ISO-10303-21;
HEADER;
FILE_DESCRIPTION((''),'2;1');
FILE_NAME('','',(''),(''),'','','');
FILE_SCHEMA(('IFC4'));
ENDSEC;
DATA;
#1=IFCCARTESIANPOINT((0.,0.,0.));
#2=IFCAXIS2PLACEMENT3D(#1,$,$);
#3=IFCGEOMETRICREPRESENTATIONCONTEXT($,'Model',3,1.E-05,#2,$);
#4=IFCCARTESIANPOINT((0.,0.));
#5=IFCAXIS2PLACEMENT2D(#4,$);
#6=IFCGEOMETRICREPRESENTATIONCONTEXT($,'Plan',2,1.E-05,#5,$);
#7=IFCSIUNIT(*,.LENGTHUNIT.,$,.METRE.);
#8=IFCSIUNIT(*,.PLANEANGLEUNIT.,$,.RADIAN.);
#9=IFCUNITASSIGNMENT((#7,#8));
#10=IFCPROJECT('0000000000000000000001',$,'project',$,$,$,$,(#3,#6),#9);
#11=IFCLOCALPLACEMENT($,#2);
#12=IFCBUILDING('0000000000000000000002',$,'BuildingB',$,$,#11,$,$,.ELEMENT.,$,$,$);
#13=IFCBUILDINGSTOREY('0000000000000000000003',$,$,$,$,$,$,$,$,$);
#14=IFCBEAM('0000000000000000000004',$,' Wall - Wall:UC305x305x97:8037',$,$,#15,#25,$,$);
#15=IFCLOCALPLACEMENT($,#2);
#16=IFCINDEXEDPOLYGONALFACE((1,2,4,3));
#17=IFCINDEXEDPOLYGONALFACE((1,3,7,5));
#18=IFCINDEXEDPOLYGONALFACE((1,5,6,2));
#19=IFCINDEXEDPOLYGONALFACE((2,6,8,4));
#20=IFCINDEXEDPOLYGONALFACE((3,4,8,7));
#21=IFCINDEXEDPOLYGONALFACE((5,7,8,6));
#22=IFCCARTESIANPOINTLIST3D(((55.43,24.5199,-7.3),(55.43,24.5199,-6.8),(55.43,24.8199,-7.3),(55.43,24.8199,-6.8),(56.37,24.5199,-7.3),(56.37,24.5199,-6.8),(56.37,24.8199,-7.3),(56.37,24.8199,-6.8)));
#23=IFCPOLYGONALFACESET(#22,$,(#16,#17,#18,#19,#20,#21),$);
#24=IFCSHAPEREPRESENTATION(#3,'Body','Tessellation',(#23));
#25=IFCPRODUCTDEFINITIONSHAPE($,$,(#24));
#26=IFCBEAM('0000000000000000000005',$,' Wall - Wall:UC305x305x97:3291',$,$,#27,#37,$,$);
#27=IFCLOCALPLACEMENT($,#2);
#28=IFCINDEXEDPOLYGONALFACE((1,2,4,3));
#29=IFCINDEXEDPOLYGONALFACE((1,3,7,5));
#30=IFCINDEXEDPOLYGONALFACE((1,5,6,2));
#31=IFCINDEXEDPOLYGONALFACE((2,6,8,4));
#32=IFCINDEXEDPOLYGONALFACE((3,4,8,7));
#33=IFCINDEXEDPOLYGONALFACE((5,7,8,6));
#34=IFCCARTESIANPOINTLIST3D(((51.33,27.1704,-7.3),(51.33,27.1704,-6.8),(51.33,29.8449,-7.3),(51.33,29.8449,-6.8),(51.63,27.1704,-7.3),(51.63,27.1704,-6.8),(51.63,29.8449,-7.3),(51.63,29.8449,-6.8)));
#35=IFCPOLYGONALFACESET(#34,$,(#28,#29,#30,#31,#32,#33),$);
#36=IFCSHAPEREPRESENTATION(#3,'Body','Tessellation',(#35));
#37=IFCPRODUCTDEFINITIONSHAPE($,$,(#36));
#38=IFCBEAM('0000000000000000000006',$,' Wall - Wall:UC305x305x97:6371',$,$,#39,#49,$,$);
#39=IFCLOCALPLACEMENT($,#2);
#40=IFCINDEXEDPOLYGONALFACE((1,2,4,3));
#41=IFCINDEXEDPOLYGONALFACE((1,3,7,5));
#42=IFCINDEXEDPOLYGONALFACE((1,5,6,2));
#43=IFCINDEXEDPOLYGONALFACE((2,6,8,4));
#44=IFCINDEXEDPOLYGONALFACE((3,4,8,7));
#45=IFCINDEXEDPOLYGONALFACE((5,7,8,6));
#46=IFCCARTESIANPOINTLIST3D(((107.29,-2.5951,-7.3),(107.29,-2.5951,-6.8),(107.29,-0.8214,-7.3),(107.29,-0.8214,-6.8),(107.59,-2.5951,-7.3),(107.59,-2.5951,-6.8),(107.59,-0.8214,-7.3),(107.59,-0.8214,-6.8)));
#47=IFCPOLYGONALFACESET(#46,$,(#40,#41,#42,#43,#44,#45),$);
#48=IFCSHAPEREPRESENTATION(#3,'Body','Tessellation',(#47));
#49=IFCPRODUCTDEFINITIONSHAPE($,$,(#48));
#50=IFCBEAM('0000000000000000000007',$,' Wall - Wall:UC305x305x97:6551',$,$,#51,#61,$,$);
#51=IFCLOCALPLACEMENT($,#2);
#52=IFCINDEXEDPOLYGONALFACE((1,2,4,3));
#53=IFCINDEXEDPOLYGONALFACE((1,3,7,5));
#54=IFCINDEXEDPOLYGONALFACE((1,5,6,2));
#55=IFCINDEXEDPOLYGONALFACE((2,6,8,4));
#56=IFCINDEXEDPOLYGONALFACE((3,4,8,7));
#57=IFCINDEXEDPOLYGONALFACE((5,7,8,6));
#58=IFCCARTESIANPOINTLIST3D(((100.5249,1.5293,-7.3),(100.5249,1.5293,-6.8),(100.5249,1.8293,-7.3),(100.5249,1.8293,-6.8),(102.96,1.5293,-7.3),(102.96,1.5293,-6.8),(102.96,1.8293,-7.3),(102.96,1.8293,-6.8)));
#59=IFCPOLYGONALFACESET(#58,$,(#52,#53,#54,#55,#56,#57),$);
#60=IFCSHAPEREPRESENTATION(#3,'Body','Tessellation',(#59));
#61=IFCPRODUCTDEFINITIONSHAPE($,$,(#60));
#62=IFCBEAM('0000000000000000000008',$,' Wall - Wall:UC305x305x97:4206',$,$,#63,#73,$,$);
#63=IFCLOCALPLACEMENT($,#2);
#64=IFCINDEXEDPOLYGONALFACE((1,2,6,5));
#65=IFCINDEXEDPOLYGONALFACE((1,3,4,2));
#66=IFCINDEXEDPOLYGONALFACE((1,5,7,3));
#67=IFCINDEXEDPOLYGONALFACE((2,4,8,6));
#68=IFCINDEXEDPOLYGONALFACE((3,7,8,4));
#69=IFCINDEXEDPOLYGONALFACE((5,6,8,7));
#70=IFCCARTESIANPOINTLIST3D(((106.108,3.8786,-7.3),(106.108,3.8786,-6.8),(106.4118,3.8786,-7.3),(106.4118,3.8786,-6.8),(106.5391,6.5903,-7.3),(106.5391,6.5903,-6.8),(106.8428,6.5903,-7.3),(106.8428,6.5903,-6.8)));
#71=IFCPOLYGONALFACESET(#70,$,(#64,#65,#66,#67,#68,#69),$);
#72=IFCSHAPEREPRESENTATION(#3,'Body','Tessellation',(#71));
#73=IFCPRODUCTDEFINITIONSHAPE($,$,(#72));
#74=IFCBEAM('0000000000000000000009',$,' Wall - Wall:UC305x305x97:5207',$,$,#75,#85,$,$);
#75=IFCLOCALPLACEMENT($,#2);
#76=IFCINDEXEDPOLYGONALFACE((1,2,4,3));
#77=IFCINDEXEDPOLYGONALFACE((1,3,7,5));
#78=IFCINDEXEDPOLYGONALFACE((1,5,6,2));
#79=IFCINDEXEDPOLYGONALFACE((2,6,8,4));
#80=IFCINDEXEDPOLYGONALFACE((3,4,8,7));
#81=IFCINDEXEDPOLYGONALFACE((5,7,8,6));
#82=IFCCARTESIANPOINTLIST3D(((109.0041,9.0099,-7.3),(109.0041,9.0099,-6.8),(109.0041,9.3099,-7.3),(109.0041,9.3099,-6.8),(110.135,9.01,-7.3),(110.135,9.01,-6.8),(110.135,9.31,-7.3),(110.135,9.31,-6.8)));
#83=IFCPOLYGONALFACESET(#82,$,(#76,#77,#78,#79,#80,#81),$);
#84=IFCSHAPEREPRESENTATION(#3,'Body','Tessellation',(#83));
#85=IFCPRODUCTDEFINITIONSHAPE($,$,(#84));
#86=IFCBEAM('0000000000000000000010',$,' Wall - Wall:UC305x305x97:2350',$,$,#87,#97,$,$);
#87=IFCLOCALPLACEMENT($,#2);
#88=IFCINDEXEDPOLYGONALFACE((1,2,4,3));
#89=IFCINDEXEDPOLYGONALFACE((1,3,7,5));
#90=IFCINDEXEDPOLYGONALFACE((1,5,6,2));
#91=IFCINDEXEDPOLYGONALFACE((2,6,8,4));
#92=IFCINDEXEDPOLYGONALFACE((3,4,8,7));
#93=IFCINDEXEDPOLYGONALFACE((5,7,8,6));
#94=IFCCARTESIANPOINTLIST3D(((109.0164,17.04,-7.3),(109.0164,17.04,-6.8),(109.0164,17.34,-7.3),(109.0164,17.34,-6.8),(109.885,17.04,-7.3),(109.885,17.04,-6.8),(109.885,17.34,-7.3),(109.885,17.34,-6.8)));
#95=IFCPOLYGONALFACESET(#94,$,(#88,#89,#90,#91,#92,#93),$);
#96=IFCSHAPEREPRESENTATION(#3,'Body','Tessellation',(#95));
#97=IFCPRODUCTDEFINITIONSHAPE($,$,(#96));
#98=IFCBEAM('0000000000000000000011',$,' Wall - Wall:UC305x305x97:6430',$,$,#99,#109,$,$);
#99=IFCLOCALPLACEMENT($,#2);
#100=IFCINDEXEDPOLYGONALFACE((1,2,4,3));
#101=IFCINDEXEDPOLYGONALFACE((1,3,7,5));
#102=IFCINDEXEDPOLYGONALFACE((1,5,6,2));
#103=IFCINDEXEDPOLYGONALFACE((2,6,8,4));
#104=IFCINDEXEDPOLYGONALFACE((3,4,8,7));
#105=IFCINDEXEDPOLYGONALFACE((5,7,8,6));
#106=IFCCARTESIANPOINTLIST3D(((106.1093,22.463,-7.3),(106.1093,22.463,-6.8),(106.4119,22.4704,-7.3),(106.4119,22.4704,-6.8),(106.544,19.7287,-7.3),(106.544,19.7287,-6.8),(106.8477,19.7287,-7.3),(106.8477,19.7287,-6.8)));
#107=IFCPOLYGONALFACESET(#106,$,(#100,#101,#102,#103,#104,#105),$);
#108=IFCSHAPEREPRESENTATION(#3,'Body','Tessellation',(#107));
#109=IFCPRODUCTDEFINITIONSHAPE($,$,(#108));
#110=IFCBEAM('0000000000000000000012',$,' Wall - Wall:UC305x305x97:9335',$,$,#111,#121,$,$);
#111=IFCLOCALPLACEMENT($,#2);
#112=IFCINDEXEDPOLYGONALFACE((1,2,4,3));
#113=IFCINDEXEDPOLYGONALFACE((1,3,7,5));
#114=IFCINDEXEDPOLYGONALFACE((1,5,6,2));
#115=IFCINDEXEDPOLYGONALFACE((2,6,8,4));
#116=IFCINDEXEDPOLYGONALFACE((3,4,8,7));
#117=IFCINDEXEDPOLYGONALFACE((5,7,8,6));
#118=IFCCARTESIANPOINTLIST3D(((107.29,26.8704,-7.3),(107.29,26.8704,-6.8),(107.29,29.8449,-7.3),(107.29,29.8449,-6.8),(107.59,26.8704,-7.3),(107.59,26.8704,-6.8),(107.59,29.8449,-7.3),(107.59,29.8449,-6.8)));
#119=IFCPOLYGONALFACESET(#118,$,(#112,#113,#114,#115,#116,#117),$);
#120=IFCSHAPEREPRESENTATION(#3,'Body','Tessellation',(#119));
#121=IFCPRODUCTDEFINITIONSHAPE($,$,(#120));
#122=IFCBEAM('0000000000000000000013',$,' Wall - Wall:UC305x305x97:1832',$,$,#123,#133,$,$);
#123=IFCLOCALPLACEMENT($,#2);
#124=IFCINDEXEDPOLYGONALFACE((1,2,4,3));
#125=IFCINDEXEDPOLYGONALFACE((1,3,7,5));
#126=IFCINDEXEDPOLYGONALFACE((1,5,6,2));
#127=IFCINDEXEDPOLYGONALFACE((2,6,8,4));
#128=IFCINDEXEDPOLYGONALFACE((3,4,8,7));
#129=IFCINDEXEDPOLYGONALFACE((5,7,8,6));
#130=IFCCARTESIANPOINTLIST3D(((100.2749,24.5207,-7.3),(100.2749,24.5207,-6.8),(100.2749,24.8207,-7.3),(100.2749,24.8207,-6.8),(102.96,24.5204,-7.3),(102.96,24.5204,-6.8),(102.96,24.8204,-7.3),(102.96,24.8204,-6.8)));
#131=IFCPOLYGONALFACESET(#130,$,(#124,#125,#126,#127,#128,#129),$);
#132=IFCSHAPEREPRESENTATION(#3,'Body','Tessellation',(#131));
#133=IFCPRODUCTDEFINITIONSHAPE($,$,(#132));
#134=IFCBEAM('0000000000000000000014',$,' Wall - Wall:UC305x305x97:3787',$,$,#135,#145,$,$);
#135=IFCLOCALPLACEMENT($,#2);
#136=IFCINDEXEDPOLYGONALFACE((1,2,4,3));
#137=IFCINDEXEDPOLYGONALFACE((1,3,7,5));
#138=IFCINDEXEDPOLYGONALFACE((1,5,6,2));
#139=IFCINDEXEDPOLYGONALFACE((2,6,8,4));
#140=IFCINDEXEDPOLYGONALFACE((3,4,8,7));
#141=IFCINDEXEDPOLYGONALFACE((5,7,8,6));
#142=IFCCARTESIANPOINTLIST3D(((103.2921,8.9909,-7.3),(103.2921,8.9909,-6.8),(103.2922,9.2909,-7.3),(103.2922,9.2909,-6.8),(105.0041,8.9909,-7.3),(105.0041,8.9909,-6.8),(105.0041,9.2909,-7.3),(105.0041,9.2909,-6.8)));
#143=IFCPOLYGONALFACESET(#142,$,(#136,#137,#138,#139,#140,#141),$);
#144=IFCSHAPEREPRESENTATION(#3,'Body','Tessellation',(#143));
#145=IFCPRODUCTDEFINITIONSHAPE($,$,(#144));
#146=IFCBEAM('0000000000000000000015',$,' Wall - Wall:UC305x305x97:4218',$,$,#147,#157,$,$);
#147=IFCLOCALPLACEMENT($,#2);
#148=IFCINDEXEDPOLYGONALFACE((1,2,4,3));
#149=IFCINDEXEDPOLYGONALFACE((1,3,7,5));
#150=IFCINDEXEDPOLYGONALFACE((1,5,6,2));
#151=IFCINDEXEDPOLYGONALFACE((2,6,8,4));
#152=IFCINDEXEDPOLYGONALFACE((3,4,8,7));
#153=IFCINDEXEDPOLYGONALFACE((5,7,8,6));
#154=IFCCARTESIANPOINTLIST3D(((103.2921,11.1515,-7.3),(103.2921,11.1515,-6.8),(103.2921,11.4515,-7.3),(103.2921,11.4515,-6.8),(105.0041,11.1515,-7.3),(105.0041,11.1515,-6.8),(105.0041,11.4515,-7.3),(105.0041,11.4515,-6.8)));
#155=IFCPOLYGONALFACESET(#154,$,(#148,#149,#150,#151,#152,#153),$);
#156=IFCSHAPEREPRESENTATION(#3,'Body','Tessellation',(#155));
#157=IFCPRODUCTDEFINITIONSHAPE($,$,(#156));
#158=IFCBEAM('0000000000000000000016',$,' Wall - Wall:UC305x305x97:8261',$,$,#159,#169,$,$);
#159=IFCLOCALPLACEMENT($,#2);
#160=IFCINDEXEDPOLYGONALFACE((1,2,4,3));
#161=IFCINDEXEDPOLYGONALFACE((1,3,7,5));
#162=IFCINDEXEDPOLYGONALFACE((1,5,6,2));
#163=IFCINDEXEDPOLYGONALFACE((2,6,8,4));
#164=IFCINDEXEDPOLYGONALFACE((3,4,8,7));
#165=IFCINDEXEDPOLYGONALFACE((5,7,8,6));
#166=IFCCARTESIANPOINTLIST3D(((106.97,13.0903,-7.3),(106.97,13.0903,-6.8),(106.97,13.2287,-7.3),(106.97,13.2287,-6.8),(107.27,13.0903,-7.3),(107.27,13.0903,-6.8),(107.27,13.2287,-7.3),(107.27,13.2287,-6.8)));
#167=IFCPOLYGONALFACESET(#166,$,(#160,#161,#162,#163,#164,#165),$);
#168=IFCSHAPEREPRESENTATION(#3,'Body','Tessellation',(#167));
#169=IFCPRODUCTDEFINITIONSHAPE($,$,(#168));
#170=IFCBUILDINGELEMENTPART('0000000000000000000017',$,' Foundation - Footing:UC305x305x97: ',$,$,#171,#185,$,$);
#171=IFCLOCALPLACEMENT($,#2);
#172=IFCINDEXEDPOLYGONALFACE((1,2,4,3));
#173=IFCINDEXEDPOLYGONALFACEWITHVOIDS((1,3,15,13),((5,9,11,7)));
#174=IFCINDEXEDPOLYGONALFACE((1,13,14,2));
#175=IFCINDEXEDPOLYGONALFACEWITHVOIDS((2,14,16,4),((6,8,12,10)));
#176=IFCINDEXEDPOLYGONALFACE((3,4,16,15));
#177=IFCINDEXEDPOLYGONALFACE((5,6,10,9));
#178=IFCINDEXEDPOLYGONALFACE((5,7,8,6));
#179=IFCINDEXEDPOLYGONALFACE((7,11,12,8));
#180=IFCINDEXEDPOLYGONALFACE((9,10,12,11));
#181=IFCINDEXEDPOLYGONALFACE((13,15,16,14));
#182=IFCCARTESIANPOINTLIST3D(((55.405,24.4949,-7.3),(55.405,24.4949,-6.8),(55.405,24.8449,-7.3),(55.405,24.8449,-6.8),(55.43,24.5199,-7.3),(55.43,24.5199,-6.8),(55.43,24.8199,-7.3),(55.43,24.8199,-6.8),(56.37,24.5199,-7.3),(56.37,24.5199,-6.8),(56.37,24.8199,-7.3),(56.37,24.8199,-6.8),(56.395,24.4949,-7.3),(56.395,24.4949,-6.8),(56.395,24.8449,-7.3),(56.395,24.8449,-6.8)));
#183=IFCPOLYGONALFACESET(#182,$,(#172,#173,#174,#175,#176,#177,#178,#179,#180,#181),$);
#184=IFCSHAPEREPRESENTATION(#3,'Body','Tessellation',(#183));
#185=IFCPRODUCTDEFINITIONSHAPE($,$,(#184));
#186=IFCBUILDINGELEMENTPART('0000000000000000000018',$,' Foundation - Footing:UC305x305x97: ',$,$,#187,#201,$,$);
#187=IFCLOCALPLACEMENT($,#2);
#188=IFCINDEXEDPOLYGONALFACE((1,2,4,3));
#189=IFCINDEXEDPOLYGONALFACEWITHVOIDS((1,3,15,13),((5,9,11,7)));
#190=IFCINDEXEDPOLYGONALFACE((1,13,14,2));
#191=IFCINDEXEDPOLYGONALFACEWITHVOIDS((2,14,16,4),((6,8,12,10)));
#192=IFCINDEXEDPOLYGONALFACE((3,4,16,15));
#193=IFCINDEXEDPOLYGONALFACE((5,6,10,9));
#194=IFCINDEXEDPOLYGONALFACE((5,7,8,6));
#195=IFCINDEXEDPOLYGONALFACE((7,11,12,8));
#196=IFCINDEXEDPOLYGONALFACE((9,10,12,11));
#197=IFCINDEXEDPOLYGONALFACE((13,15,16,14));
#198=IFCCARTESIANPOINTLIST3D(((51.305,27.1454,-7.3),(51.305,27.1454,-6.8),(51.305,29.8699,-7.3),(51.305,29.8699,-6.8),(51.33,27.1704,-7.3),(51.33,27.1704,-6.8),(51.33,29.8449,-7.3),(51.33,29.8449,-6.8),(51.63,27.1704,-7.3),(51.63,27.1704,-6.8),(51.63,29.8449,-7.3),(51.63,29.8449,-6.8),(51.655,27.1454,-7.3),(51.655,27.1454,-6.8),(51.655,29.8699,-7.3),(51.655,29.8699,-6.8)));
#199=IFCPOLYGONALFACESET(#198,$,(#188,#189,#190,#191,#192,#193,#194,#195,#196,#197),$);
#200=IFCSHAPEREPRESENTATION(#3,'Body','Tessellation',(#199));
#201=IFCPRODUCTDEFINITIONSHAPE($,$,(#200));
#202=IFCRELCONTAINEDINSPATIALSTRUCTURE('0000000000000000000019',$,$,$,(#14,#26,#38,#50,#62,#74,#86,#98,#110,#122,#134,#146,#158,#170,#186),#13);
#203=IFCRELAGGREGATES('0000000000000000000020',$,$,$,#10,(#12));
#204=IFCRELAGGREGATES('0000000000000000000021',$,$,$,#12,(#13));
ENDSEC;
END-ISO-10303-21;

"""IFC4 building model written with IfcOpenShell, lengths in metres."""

from ifc_helpers import new_model, si_unit, origin, origin_2d, place, context, project, spatial, polyline, outline, extrude, element, save


model = new_model("IFC4")

# Units and contexts
model_context = context("Model", 3, precision=1e-05, world=origin())
plan_context = context("Plan", 2, precision=1e-05, world=origin_2d())
ifc_project = project(units=[si_unit("LENGTHUNIT", "METRE"), si_unit("PLANEANGLEUNIT", "RADIAN")], contexts=[model_context, plan_context])

# Building, storey
building_placement = place(None, origin())
building = spatial("IfcBuilding", under=ifc_project, at=building_placement, Name="BuildingB", CompositionType="ELEMENT")
storey = spatial("IfcBuildingStorey", under=building)

# Beams
element("IfcBeam", 1, inside=storey, Name=" Wall - Wall:UC305x305x97:8037", context=model_context, shape_type="SweptSolid", body=[
    extrude(outline(polyline([(55.43, 24.5199, -7.3), (55.43, 24.8199, -7.3), (56.37, 24.8199, -7.3), (56.37, 24.5199, -7.3), (55.43, 24.5199, -7.3)])), None, (0.0, 0.0, 1.0), 0.5),
])
element("IfcBeam", 2, inside=storey, Name=" Wall - Wall:UC305x305x97:3291", context=model_context, shape_type="SweptSolid", body=[
    extrude(outline(polyline([(51.33, 27.1704, -7.3), (51.63, 27.1704, -7.3), (51.63, 29.8449, -7.3), (51.33, 29.8449, -7.3), (51.33, 27.1704, -7.3)])), None, (0.0, 0.0, 1.0), 0.5),
])
element("IfcBeam", 3, inside=storey, Name=" Wall - Wall:UC305x305x97:6371", context=model_context, shape_type="SweptSolid", body=[
    extrude(outline(polyline([(107.59, -2.5951, -7.3), (107.29, -2.5951, -7.3), (107.29, -0.8214, -7.3), (107.59, -0.8214, -7.3), (107.59, -2.5951, -7.3)])), None, (0.0, 0.0, 1.0), 0.5),
])
element("IfcBeam", 4, inside=storey, Name=" Wall - Wall:UC305x305x97:6551", context=model_context, shape_type="SweptSolid", body=[
    extrude(outline(polyline([(102.96, 1.5293, -7.3), (102.96, 1.8293, -7.3), (100.5249, 1.8293, -7.3), (100.5249, 1.5293, -7.3), (102.96, 1.5293, -7.3)])), None, (0.0, 0.0, 1.0), 0.5),
])
element("IfcBeam", 5, inside=storey, Name=" Wall - Wall:UC305x305x97:4206", context=model_context, shape_type="SweptSolid", body=[
    extrude(outline(polyline([(106.4118, 3.8786, -7.3), (106.8428, 6.5903, -7.3), (106.5391, 6.5903, -7.3), (106.108, 3.8786, -7.3), (106.4118, 3.8786, -7.3)])), None, (0.0, 0.0, 1.0), 0.5),
])
element("IfcBeam", 6, inside=storey, Name=" Wall - Wall:UC305x305x97:5207", context=model_context, shape_type="SweptSolid", body=[
    extrude(outline(polyline([(110.135, 9.01, -7.3), (110.135, 9.31, -7.3), (109.0041, 9.3099, -7.3), (109.0041, 9.0099, -7.3), (110.135, 9.01, -7.3)])), None, (0.0, 0.0, 1.0), 0.5),
])
element("IfcBeam", 7, inside=storey, Name=" Wall - Wall:UC305x305x97:2350", context=model_context, shape_type="SweptSolid", body=[
    extrude(outline(polyline([(109.885, 17.04, -7.3), (109.885, 17.34, -7.3), (109.0164, 17.34, -7.3), (109.0164, 17.04, -7.3), (109.885, 17.04, -7.3)])), None, (0.0, 0.0, 1.0), 0.5),
])
element("IfcBeam", 8, inside=storey, Name=" Wall - Wall:UC305x305x97:6430", context=model_context, shape_type="SweptSolid", body=[
    extrude(outline(polyline([(106.544, 19.7287, -7.3), (106.8477, 19.7287, -7.3), (106.4119, 22.4704, -7.3), (106.1093, 22.463, -7.3), (106.544, 19.7287, -7.3)])), None, (0.0, 0.0, 1.0), 0.5),
])
element("IfcBeam", 9, inside=storey, Name=" Wall - Wall:UC305x305x97:9335", context=model_context, shape_type="SweptSolid", body=[
    extrude(outline(polyline([(107.29, 26.8704, -7.3), (107.59, 26.8704, -7.3), (107.59, 29.8449, -7.3), (107.29, 29.8449, -7.3), (107.29, 26.8704, -7.3)])), None, (0.0, 0.0, 1.0), 0.5),
])
element("IfcBeam", 10, inside=storey, Name=" Wall - Wall:UC305x305x97:1832", context=model_context, shape_type="SweptSolid", body=[
    extrude(outline(polyline([(102.96, 24.5204, -7.3), (102.96, 24.8204, -7.3), (100.2749, 24.8207, -7.3), (100.2749, 24.5207, -7.3), (102.96, 24.5204, -7.3)])), None, (0.0, 0.0, 1.0), 0.5),
])
element("IfcBeam", 11, inside=storey, Name=" Wall - Wall:UC305x305x97:3787", context=model_context, shape_type="SweptSolid", body=[
    extrude(outline(polyline([(105.0041, 8.9909, -7.3), (105.0041, 9.2909, -7.3), (103.2922, 9.2909, -7.3), (103.2921, 8.9909, -7.3), (105.0041, 8.9909, -7.3)])), None, (0.0, 0.0, 1.0), 0.5),
])
element("IfcBeam", 12, inside=storey, Name=" Wall - Wall:UC305x305x97:4218", context=model_context, shape_type="SweptSolid", body=[
    extrude(outline(polyline([(105.0041, 11.1515, -7.3), (105.0041, 11.4515, -7.3), (103.2921, 11.4515, -7.3), (103.2921, 11.1515, -7.3), (105.0041, 11.1515, -7.3)])), None, (0.0, 0.0, 1.0), 0.5),
])
element("IfcBeam", 13, inside=storey, Name=" Wall - Wall:UC305x305x97:8261", context=model_context, shape_type="SweptSolid", body=[
    extrude(outline(polyline([(107.27, 13.0903, -7.3), (107.27, 13.2287, -7.3), (106.97, 13.2287, -7.3), (106.97, 13.0903, -7.3), (107.27, 13.0903, -7.3)])), None, (0.0, 0.0, 1.0), 0.5),
])

# Building element parts, openings
building_element_part_1 = element("IfcBuildingElementPart", 14, inside=storey, Name=" Foundation - Footing:UC305x305x97: ", context=model_context, shape_type="SweptSolid", body=[
    extrude(outline(polyline([(55.405, 24.4949, -7.3), (55.405, 24.8449, -7.3), (56.395, 24.8449, -7.3), (56.395, 24.4949, -7.3), (55.405, 24.4949, -7.3)])), None, (0.0, 0.0, 1.0), 0.5),
])
element("IfcOpeningElement", 15, inside=storey, cuts=building_element_part_1, context=model_context, shape_type="SweptSolid", body=[
    extrude(outline(polyline([(55.43, 24.5199, -7.3), (55.43, 24.8199, -7.3), (56.37, 24.8199, -7.3), (56.37, 24.5199, -7.3), (55.43, 24.5199, -7.3)])), None, (0.0, 0.0, 1.0), 0.5),
])
building_element_part_2 = element("IfcBuildingElementPart", 16, inside=storey, Name=" Foundation - Footing:UC305x305x97: ", context=model_context, shape_type="SweptSolid", body=[
    extrude(outline(polyline([(51.305, 27.1454, -7.3), (51.655, 27.1454, -7.3), (51.655, 29.8699, -7.3), (51.305, 29.8699, -7.3), (51.305, 27.1454, -7.3)])), None, (0.0, 0.0, 1.0), 0.5),
])
element("IfcOpeningElement", 17, inside=storey, cuts=building_element_part_2, context=model_context, shape_type="SweptSolid", body=[
    extrude(outline(polyline([(51.33, 27.1704, -7.3), (51.63, 27.1704, -7.3), (51.63, 29.8449, -7.3), (51.33, 29.8449, -7.3), (51.33, 27.1704, -7.3)])), None, (0.0, 0.0, 1.0), 0.5),
])

save(model, "model.ifc")
